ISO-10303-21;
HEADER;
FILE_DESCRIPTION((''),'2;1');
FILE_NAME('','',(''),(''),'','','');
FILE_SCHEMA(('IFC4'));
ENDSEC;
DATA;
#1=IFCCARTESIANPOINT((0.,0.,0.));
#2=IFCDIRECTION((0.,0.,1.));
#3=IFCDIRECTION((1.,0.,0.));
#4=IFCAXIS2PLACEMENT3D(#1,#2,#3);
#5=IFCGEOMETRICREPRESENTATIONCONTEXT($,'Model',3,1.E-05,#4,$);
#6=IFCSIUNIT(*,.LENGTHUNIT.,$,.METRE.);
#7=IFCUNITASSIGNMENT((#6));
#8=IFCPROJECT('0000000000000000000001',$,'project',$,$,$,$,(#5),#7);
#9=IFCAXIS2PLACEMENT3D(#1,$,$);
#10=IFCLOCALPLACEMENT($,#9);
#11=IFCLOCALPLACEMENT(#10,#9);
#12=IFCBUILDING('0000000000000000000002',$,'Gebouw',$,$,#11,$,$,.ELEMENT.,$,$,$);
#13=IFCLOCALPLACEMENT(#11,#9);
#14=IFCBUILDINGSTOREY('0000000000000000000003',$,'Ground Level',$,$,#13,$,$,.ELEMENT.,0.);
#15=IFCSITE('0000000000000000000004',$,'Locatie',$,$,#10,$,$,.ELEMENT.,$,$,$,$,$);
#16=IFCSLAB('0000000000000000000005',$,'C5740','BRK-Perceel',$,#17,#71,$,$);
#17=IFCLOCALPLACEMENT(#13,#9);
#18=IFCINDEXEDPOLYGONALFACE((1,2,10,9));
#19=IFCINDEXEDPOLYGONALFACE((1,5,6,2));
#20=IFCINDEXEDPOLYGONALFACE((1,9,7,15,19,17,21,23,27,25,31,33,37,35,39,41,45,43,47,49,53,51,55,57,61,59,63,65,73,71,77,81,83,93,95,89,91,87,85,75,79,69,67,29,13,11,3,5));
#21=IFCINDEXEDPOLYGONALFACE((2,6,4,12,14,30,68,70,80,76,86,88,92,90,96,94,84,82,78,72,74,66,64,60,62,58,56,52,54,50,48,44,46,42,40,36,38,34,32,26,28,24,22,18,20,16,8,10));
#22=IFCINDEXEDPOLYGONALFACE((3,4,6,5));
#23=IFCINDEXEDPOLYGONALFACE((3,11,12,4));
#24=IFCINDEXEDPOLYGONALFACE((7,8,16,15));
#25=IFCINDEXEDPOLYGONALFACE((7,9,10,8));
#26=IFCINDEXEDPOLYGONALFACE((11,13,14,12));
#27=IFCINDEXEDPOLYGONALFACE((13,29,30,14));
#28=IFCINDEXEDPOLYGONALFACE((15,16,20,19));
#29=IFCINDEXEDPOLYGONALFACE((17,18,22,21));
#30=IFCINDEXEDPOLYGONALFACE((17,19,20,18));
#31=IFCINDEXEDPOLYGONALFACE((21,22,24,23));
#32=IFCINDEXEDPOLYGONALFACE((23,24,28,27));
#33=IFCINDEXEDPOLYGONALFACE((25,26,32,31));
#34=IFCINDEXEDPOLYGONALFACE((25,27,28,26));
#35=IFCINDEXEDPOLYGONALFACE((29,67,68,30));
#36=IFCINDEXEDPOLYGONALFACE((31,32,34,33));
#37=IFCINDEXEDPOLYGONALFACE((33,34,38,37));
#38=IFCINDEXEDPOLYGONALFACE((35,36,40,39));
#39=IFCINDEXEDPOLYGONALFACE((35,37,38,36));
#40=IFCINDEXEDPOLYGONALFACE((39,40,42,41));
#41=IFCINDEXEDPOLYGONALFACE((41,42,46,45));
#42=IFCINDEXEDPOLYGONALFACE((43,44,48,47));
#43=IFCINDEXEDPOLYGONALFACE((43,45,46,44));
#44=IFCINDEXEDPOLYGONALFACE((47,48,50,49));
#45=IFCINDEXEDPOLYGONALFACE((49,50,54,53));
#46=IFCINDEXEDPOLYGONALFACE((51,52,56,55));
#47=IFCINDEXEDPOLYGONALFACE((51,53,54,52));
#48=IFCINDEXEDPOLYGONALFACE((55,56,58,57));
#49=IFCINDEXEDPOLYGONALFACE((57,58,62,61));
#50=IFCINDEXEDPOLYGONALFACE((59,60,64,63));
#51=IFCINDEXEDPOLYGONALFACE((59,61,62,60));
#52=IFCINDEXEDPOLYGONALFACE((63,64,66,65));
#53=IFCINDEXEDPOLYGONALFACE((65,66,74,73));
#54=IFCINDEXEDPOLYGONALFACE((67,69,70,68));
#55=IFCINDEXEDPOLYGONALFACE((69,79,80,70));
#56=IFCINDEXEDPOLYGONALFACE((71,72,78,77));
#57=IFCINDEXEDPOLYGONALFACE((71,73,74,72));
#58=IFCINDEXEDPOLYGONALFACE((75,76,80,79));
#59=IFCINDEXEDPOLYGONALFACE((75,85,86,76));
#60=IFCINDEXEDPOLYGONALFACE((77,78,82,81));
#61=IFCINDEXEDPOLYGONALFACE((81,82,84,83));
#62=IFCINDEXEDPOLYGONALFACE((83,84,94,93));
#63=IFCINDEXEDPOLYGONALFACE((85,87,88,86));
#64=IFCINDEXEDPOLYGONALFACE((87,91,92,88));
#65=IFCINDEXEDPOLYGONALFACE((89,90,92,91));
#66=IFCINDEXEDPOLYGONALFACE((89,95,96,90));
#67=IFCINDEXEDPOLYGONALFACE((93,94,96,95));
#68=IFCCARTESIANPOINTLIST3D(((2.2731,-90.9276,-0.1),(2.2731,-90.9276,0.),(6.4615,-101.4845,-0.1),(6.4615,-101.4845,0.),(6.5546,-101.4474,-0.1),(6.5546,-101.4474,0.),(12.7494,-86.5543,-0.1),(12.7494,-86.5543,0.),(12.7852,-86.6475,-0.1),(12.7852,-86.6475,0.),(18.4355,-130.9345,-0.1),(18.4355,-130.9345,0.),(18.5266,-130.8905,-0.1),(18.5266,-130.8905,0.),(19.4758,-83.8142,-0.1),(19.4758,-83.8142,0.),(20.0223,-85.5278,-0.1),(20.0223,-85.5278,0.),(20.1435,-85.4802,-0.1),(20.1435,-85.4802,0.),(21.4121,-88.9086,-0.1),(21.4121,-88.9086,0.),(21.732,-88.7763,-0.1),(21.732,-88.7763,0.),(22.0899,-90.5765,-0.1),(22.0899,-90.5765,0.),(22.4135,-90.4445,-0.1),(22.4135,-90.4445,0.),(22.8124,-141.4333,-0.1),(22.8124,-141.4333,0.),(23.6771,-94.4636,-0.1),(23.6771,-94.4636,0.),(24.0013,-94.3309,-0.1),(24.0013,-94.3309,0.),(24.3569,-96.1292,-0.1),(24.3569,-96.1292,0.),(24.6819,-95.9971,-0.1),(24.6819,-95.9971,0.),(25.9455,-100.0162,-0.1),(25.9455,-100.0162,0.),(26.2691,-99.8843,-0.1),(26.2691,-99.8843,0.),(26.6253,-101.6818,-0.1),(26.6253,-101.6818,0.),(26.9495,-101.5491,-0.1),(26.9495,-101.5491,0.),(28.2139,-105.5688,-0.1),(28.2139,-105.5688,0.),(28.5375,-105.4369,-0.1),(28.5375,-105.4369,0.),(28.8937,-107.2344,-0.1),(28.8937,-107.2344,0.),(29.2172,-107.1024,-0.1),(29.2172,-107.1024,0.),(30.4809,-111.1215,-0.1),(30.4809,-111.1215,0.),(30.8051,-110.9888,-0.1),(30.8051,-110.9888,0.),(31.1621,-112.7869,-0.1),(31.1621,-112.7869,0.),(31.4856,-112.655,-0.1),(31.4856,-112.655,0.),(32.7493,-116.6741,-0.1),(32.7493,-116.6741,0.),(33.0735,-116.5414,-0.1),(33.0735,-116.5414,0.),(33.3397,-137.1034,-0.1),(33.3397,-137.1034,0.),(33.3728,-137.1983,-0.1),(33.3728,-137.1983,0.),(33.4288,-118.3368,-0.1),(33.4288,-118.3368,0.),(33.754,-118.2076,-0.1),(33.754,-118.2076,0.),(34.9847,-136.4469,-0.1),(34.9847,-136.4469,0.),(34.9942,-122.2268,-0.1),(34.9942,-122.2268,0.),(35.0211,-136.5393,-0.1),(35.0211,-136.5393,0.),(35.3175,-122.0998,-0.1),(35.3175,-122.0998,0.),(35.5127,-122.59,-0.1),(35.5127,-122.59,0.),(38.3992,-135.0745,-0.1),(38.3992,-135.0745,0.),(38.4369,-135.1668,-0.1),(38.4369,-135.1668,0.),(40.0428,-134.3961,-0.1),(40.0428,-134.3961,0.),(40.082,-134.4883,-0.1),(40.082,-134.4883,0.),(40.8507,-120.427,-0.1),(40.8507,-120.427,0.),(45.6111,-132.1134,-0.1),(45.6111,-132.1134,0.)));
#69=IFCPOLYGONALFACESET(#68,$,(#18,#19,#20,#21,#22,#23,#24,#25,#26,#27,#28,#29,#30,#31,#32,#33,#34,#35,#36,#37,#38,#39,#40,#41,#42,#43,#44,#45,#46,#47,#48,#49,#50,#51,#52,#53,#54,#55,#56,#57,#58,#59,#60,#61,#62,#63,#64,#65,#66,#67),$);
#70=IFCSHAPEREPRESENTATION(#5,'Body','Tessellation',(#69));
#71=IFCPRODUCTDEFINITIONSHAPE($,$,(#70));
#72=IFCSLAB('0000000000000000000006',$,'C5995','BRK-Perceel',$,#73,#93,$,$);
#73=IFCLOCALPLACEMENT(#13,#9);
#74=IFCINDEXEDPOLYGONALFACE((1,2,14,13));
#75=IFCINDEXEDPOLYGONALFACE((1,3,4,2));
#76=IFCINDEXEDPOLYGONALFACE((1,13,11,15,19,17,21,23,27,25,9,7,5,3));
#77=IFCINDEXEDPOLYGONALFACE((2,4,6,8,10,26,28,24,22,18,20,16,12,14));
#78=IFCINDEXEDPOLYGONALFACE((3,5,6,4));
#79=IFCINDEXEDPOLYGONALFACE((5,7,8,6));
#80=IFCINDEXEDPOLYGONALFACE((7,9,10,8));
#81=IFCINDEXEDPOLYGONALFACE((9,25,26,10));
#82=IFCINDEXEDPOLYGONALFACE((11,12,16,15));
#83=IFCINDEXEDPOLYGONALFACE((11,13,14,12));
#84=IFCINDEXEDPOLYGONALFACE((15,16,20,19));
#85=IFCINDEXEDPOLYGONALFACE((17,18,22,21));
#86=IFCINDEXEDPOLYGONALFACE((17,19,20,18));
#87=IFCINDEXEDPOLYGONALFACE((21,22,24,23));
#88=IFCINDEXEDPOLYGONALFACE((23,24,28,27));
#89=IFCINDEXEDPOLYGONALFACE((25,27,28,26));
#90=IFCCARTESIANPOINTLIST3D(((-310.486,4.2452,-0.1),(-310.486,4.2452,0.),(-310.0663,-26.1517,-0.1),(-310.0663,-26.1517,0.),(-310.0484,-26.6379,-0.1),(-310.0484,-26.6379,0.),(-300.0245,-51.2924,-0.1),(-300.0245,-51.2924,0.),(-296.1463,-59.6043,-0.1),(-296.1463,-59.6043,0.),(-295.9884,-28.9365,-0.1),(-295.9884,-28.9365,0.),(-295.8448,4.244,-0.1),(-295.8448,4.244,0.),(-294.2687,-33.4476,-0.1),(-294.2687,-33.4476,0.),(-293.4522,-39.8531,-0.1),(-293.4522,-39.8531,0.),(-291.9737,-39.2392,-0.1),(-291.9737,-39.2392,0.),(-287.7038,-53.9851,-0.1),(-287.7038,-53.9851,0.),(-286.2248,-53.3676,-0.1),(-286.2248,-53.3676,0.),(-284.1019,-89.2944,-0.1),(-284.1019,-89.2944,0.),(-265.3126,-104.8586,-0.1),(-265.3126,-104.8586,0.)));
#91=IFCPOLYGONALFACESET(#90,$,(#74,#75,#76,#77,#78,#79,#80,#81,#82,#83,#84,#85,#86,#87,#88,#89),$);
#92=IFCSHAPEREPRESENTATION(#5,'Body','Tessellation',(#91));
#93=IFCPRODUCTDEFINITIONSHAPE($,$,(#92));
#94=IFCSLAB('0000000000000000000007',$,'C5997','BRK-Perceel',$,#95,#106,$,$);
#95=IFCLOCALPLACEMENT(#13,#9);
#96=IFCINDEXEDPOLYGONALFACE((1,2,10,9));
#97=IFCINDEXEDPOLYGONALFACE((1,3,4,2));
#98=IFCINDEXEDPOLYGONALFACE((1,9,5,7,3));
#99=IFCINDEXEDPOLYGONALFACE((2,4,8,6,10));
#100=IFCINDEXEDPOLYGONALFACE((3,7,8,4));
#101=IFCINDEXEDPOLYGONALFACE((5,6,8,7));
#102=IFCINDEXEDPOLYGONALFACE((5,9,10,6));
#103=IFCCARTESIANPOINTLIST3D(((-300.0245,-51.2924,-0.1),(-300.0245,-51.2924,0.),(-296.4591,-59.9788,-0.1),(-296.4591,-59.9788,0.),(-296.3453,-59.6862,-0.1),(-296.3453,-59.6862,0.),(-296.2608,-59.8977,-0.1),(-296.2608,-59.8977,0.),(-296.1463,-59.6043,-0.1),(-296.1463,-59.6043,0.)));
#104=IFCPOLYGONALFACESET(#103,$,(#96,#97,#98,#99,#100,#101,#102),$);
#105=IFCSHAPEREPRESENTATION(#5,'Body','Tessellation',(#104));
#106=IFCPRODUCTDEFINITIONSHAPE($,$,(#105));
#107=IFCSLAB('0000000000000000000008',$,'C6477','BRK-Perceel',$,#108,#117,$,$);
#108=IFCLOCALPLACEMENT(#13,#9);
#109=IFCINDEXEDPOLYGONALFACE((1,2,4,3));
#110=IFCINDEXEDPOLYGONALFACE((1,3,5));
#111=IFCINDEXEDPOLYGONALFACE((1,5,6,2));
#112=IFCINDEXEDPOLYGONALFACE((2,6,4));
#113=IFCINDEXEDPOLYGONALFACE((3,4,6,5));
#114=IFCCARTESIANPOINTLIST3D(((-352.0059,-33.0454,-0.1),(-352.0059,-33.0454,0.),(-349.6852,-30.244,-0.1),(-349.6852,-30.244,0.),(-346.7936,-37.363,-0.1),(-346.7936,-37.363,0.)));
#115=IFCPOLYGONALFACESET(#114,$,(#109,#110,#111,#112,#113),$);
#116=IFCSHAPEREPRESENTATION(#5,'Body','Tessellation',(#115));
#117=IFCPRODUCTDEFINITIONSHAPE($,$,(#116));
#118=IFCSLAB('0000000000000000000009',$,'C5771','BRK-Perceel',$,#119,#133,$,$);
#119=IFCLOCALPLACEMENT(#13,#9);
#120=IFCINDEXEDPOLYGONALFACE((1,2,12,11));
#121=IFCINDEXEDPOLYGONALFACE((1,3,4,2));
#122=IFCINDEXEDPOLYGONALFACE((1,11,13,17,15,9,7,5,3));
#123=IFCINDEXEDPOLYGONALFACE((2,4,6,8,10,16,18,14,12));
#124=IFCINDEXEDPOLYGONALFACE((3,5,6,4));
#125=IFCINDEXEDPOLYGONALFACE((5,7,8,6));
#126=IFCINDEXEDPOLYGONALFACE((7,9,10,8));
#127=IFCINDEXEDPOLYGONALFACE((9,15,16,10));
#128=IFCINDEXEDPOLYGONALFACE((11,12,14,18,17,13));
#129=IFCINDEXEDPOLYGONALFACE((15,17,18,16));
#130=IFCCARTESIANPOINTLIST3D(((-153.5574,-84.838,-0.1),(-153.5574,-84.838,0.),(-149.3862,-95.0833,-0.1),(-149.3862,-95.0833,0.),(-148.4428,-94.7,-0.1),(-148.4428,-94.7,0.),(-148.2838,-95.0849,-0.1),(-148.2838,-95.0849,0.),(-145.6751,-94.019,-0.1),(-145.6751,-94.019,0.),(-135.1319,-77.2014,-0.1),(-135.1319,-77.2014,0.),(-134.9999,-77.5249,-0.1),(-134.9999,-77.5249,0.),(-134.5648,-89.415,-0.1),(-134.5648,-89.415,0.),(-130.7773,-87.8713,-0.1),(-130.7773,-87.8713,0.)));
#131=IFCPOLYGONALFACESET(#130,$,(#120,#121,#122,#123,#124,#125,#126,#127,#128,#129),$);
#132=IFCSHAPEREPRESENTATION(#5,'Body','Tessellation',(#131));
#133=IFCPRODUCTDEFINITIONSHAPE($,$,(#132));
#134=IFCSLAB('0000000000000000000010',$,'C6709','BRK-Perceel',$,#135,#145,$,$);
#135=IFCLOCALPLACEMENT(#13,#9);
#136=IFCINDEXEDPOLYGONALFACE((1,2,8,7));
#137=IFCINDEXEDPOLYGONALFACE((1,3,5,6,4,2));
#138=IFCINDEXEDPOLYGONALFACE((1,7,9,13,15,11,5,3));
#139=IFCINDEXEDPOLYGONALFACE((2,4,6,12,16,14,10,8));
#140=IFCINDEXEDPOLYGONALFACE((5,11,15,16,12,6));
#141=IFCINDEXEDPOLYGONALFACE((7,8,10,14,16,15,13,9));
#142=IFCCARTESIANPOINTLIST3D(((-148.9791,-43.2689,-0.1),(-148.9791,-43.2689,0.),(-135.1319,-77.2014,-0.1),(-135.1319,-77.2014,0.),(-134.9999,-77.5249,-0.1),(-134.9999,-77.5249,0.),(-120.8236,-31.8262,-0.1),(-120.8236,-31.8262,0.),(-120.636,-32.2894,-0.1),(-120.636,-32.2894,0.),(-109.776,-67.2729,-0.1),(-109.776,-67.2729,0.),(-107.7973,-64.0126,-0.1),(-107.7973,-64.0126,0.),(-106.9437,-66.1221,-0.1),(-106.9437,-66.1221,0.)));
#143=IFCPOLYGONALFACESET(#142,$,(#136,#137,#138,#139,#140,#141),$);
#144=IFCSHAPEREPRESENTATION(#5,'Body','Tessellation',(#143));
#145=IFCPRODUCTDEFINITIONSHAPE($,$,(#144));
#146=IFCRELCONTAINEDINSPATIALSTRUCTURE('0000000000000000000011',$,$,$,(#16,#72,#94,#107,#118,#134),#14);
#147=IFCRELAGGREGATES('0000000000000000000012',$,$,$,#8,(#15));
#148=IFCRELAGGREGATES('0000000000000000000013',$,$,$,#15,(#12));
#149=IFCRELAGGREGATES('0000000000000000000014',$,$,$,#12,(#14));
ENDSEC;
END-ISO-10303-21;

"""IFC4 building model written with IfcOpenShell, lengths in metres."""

from ifc_helpers import new_model, si_unit, frame, origin, origin_with_axes, place, context, project, spatial, polyline, outline, extrude, element, save


model = new_model("IFC4")

# Units and contexts
model_context = context("Model", 3, precision=1e-05, world=origin_with_axes())
ifc_project = project(units=[si_unit("LENGTHUNIT", "METRE")], contexts=[model_context])

# Site, building, storey
site_placement = place(None, origin())
site = spatial("IfcSite", under=ifc_project, at=site_placement, Name="Locatie", CompositionType="ELEMENT")
building_placement = place(site_placement, origin())
building = spatial("IfcBuilding", under=site, at=building_placement, Name="Gebouw", CompositionType="ELEMENT")
storey_placement = place(building_placement, origin())
storey = spatial("IfcBuildingStorey", under=building, at=storey_placement, Name="Ground Level", CompositionType="ELEMENT", Elevation=0.0)

# Slabs
slab_1_placement = place(storey_placement, origin())
element("IfcSlab", 1, at=slab_1_placement, inside=storey, Name="C5740", Description="BRK-Perceel", context=model_context, shape_type="SweptSolid", body=[
    extrude(outline(polyline([(33.4288, -118.3368), (34.9942, -122.2268), (35.3175, -122.0998), (35.5127, -122.59), (40.8507, -120.427), (45.6111, -132.1134), (40.0428, -134.3961), (40.082, -134.4883), (38.4369, -135.1668), (38.3992, -135.0745), (34.9847, -136.4469), (35.0211, -136.5393), (33.3728, -137.1983), (33.3397, -137.1034), (22.8124, -141.4333), (18.5266, -130.8905), (18.4355, -130.9345), (6.4615, -101.4845), (6.5546, -101.4474), (2.2731, -90.9276), (12.7852, -86.6475), (12.7494, -86.5543), (19.4758, -83.8142), (20.1435, -85.4802), (20.0223, -85.5278), (21.4121, -88.9086), (21.732, -88.7763), (22.4135, -90.4445), (22.0899, -90.5765), (23.6771, -94.4636), (24.0013, -94.3309), (24.6819, -95.9971), (24.3569, -96.1292), (25.9455, -100.0162), (26.2691, -99.8843), (26.9495, -101.5491), (26.6253, -101.6818), (28.2139, -105.5688), (28.5375, -105.4369), (29.2172, -107.1024), (28.8937, -107.2344), (30.4809, -111.1215), (30.8051, -110.9888), (31.4856, -112.655), (31.1621, -112.7869), (32.7493, -116.6741), (33.0735, -116.5414), (33.754, -118.2076), (33.4288, -118.3368)])), frame((0.0, 0.0, -0.1), z_axis=(0.0, 0.0, 1.0), x_axis=(1.0, 0.0, 0.0)), (0.0, 0.0, 1.0), 0.1),
])
slab_2_placement = place(storey_placement, origin())
element("IfcSlab", 2, at=slab_2_placement, inside=storey, Name="C5995", Description="BRK-Perceel", context=model_context, shape_type="SweptSolid", body=[
    extrude(outline(polyline([(-296.1463, -59.6043), (-300.0245, -51.2924), (-310.0484, -26.6379), (-310.0663, -26.1517), (-310.486, 4.2452), (-295.8448, 4.244), (-295.9884, -28.9365), (-294.2687, -33.4476), (-291.9737, -39.2392), (-293.4522, -39.8531), (-287.7038, -53.9851), (-286.2248, -53.3676), (-265.3126, -104.8586), (-284.1019, -89.2944), (-296.1463, -59.6043)])), frame((0.0, 0.0, -0.1), z_axis=(0.0, 0.0, 1.0), x_axis=(1.0, 0.0, 0.0)), (0.0, 0.0, 1.0), 0.1),
])
slab_3_placement = place(storey_placement, origin())
element("IfcSlab", 3, at=slab_3_placement, inside=storey, Name="C5997", Description="BRK-Perceel", context=model_context, shape_type="SweptSolid", body=[
    extrude(outline(polyline([(-300.0245, -51.2924), (-296.1463, -59.6043), (-296.3453, -59.6862), (-296.2608, -59.8977), (-296.4591, -59.9788), (-300.0245, -51.2924)])), frame((0.0, 0.0, -0.1), z_axis=(0.0, 0.0, 1.0), x_axis=(1.0, 0.0, 0.0)), (0.0, 0.0, 1.0), 0.1),
])
slab_4_placement = place(storey_placement, origin())
element("IfcSlab", 4, at=slab_4_placement, inside=storey, Name="C6477", Description="BRK-Perceel", context=model_context, shape_type="SweptSolid", body=[
    extrude(outline(polyline([(-346.7936, -37.363), (-352.0059, -33.0454), (-349.6852, -30.244), (-346.7936, -37.363)])), frame((0.0, 0.0, -0.1), z_axis=(0.0, 0.0, 1.0), x_axis=(1.0, 0.0, 0.0)), (0.0, 0.0, 1.0), 0.1),
])
slab_5_placement = place(storey_placement, origin())
element("IfcSlab", 5, at=slab_5_placement, inside=storey, Name="C5771", Description="BRK-Perceel", context=model_context, shape_type="SweptSolid", body=[
    extrude(outline(polyline([(-130.7773, -87.8713), (-134.5648, -89.415), (-145.6751, -94.019), (-148.2838, -95.0849), (-148.4428, -94.7), (-149.3862, -95.0833), (-153.5574, -84.838), (-135.1319, -77.2014), (-134.9999, -77.5249), (-130.7773, -87.8713)])), frame((0.0, 0.0, -0.1), z_axis=(0.0, 0.0, 1.0), x_axis=(1.0, 0.0, 0.0)), (0.0, 0.0, 1.0), 0.1),
])
slab_6_placement = place(storey_placement, origin())
element("IfcSlab", 6, at=slab_6_placement, inside=storey, Name="C6709", Description="BRK-Perceel", context=model_context, shape_type="SweptSolid", body=[
    extrude(outline(polyline([(-109.776, -67.2729), (-134.9999, -77.5249), (-135.1319, -77.2014), (-148.9791, -43.2689), (-120.8236, -31.8262), (-120.636, -32.2894), (-107.7973, -64.0126), (-106.9437, -66.1221), (-109.776, -67.2729)])), frame((0.0, 0.0, -0.1), z_axis=(0.0, 0.0, 1.0), x_axis=(1.0, 0.0, 0.0)), (0.0, 0.0, 1.0), 0.1),
])

save(model, "model.ifc")
